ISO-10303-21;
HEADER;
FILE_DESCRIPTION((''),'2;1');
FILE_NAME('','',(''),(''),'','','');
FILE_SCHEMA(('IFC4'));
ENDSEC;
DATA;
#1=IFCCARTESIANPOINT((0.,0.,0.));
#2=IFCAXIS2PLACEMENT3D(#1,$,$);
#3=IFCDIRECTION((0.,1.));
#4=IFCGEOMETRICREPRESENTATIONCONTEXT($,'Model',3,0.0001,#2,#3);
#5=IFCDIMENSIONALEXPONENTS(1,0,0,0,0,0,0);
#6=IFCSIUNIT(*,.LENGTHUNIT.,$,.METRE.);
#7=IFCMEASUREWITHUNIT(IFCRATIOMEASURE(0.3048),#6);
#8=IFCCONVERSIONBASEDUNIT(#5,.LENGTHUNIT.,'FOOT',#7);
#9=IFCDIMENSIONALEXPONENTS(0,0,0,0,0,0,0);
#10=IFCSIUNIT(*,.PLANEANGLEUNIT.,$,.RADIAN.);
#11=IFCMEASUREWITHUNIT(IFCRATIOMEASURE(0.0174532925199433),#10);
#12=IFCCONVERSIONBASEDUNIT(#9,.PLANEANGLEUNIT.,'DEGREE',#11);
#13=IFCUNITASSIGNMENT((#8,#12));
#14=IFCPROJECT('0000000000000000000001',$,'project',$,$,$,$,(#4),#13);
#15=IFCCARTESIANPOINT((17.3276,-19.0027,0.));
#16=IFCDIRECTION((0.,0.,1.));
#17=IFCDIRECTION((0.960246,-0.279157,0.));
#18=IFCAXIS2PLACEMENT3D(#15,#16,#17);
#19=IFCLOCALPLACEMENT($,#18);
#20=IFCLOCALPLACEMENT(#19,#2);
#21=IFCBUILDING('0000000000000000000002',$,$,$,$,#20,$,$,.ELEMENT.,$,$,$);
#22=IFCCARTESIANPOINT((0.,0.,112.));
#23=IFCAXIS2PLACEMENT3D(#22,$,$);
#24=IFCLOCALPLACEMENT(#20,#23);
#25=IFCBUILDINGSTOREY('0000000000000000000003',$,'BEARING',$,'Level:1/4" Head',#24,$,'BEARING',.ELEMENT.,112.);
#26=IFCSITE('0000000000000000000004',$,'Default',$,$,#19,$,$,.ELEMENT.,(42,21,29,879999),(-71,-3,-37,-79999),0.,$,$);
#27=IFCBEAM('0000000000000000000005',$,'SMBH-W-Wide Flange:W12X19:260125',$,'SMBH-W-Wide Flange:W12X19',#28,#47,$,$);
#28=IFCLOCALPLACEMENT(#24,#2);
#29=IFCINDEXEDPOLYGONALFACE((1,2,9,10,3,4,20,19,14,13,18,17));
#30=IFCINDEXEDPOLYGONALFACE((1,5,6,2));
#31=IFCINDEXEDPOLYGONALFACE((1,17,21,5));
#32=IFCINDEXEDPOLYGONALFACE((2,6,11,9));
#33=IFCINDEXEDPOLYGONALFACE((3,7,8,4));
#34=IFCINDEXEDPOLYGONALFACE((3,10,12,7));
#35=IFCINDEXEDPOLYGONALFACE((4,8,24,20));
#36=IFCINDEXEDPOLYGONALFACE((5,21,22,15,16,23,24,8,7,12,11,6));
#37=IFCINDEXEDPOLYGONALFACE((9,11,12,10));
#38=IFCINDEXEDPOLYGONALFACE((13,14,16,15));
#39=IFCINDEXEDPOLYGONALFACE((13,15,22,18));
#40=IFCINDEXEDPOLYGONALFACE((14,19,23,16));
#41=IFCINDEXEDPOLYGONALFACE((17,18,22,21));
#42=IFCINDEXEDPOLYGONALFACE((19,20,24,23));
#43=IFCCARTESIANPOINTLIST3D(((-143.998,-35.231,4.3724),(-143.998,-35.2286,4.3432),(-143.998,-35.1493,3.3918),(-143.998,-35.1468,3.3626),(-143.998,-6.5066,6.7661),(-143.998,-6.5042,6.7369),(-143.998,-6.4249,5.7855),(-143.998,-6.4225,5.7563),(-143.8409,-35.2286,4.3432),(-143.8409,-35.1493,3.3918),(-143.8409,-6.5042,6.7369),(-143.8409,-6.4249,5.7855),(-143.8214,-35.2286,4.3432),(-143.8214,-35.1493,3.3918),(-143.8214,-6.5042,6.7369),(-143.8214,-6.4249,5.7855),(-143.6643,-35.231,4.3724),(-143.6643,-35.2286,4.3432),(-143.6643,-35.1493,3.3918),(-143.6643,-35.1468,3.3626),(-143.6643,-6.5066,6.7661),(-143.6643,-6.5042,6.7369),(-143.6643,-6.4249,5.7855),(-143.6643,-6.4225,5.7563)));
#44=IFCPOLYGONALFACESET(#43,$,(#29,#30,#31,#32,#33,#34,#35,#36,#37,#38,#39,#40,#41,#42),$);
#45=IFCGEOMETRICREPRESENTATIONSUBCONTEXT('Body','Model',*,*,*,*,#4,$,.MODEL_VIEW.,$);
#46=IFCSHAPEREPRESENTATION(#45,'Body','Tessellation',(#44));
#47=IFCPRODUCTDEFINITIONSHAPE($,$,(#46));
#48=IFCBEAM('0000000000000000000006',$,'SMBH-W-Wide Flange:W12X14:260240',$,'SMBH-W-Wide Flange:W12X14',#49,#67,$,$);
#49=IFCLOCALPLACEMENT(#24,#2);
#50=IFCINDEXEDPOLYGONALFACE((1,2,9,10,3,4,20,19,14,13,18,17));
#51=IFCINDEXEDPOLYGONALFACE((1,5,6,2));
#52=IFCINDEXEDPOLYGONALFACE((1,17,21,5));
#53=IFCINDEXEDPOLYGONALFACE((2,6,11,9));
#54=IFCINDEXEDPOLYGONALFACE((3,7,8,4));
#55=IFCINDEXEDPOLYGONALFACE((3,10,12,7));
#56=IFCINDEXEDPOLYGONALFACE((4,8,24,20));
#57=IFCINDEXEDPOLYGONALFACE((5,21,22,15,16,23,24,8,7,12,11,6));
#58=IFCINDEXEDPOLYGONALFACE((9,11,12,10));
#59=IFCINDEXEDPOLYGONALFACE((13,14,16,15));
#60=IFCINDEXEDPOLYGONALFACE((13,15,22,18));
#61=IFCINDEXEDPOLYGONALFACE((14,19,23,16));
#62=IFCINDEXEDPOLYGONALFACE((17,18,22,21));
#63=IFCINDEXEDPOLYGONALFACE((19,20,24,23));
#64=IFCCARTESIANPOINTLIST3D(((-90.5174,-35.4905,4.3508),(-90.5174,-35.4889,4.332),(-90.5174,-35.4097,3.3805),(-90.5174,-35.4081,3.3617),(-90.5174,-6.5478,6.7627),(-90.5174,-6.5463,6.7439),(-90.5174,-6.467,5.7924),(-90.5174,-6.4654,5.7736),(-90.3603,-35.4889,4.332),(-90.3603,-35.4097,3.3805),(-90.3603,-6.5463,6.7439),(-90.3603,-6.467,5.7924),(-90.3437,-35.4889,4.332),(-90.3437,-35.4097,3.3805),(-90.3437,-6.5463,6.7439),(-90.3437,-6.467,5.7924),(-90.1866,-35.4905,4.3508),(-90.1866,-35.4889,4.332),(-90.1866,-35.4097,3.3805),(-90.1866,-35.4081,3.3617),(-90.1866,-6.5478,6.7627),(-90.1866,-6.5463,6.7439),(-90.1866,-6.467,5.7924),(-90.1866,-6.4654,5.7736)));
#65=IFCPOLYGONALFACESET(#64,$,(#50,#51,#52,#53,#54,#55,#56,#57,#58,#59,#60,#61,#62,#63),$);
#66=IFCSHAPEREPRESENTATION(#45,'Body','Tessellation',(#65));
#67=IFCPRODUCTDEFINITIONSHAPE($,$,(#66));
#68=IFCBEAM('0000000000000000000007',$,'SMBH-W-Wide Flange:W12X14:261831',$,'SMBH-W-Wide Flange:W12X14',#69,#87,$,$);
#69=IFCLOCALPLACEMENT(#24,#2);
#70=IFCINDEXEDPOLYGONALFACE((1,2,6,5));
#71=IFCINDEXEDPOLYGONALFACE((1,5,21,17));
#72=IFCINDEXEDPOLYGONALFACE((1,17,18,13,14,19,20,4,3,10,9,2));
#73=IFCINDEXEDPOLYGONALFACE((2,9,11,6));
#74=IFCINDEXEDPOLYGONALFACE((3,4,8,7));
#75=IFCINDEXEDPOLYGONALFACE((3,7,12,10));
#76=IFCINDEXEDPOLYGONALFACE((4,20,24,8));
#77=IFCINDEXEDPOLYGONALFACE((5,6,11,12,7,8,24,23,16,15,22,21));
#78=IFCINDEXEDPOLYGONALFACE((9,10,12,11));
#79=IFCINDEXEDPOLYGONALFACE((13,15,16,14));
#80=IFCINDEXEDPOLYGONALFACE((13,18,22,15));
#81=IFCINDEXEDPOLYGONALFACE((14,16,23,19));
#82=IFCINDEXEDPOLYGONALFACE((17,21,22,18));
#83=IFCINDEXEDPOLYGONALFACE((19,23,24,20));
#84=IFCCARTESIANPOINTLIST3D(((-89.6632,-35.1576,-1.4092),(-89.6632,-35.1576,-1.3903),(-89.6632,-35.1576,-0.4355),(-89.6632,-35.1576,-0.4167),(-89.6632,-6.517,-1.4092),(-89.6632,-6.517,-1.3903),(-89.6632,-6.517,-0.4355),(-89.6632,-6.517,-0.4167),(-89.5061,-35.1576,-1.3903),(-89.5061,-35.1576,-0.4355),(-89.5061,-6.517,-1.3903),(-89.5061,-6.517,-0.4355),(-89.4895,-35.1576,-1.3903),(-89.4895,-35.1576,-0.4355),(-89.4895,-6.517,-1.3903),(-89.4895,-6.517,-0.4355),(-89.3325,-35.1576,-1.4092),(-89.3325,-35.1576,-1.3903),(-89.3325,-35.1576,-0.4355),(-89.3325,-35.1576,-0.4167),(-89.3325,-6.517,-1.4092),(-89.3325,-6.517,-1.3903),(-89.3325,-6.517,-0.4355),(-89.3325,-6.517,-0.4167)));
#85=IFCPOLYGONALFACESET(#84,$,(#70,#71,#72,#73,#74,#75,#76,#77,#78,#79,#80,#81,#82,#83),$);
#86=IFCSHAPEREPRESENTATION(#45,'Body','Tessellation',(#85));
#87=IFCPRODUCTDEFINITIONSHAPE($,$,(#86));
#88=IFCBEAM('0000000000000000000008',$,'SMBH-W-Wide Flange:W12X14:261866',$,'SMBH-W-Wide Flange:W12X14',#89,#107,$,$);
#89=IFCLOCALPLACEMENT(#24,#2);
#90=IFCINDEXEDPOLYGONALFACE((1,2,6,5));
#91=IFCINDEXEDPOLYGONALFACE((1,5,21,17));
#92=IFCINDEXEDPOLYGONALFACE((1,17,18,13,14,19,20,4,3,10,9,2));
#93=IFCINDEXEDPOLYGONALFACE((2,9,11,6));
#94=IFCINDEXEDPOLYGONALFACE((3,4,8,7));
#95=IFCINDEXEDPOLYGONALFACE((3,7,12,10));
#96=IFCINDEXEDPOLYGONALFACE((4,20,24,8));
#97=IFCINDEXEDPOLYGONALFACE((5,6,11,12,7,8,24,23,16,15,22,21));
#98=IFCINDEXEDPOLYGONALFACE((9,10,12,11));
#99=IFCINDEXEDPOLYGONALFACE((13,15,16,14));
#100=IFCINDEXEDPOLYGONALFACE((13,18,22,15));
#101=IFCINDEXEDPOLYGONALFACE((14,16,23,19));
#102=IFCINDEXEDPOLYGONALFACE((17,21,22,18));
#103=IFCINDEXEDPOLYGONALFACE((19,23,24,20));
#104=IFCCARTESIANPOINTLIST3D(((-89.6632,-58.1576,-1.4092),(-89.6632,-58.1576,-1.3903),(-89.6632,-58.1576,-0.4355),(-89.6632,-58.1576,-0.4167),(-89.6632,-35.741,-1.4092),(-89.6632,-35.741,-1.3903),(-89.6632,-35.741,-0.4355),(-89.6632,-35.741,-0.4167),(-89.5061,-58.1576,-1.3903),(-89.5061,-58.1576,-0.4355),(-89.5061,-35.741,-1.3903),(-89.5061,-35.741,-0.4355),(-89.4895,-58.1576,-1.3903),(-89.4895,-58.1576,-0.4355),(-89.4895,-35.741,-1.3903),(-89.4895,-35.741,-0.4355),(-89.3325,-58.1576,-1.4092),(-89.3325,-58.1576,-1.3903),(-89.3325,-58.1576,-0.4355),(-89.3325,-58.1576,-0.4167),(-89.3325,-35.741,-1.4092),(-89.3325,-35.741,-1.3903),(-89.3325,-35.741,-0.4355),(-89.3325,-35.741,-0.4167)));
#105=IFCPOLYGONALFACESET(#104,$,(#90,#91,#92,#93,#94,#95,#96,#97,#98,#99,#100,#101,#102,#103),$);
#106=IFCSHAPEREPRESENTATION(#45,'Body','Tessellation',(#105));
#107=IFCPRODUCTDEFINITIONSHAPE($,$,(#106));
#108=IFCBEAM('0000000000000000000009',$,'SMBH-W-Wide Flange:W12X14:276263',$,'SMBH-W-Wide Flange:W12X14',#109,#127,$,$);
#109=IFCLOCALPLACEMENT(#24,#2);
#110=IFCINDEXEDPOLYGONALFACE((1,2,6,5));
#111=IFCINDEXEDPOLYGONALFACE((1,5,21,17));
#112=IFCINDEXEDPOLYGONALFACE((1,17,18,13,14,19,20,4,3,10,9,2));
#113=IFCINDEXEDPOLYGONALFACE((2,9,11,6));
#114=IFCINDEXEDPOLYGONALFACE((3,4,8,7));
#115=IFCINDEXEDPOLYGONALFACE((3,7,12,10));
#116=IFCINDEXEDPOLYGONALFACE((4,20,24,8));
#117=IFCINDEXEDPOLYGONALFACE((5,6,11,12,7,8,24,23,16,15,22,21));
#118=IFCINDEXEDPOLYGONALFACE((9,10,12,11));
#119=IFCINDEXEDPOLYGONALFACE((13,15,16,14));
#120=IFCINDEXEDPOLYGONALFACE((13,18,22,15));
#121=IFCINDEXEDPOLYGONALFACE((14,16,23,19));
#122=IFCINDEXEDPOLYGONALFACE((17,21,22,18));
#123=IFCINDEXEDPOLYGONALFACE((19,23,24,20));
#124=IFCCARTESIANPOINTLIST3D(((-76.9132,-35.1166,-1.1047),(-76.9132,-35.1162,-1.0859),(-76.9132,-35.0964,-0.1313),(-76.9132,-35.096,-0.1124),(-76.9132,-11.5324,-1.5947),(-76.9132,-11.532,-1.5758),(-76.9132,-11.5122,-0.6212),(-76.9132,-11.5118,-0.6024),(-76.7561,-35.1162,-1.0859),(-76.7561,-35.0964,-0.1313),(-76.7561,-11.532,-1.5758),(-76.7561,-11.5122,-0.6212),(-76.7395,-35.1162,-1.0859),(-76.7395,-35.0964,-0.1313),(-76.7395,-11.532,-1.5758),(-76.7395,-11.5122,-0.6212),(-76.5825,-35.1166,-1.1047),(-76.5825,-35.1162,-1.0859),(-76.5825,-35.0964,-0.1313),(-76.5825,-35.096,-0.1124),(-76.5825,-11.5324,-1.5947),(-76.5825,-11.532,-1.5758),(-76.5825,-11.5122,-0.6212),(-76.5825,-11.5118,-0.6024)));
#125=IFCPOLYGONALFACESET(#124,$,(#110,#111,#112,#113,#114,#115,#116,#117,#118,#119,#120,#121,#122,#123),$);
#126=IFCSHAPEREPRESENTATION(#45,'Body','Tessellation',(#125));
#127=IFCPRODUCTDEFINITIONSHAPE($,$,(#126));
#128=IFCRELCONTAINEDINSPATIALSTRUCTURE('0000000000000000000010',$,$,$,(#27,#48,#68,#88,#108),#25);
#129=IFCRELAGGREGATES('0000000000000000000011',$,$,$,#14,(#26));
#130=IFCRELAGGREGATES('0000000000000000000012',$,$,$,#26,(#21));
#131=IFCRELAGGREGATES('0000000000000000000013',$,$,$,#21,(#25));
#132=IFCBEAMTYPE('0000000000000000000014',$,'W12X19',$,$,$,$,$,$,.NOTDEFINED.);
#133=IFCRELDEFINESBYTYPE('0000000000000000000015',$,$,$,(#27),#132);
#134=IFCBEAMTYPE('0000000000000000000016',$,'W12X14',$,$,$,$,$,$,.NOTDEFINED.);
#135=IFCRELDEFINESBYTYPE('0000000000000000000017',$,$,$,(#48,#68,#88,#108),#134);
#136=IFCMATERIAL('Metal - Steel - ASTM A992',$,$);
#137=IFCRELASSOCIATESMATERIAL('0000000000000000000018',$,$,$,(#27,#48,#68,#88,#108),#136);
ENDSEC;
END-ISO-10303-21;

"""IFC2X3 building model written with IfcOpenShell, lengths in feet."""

from ifc_helpers import new_model, entity, si_unit, converted_unit, direction, frame, frame_2d, origin, place, context, subcontext, project, spatial, i_section, extrude, material, type_object, element, save


model = new_model("IFC2X3")

# Units and contexts
model_context = context("Model", 3, precision=0.0001, world=origin(), true_north=direction((0.0, 1.0)))
body_context = subcontext(model_context, "Body", "Model", "MODEL_VIEW")
ifc_project = project(units=[converted_unit("LENGTHUNIT", "FOOT", entity("IfcRatioMeasure", 0.3048), si_unit("LENGTHUNIT", "METRE"), dimensions=[1, 0, 0, 0, 0, 0, 0]), converted_unit("PLANEANGLEUNIT", "DEGREE", entity("IfcRatioMeasure", 0.0174532925199433), si_unit("PLANEANGLEUNIT", "RADIAN"), dimensions=[0, 0, 0, 0, 0, 0, 0])], contexts=[model_context])

# Site, building, storey
site_placement = place(None, frame((17.3276, -19.0027, 0.0), z_axis=(0.0, 0.0, 1.0), x_axis=(0.960246, -0.279157, 0.0)))
site = spatial("IfcSite", under=ifc_project, at=site_placement, Name="Default", CompositionType="ELEMENT", RefLatitude=(42, 21, 29, 879999), RefLongitude=(-71, -3, -37, -79999), RefElevation=0.0)
building_placement = place(site_placement, origin())
building = spatial("IfcBuilding", under=site, at=building_placement, CompositionType="ELEMENT")
storey_placement = place(building_placement, frame((0.0, 0.0, 112.0)))
storey = spatial("IfcBuildingStorey", under=building, at=storey_placement, Name="BEARING", ObjectType="Level:1/4\" Head", LongName="BEARING", CompositionType="ELEMENT", Elevation=112.0)

# Beams
ifc_material_1 = material(Name="Metal - Steel - ASTM A992")
beam_type_1 = type_object("IfcBeamType", Name="W12X19", PredefinedType="NOTDEFINED")
beam_1_placement = place(storey_placement, frame((-143.8312, -6.517, 6.8907), z_axis=(0.0, -0.083045, 0.996546), x_axis=(0.0, -0.996546, -0.083045)))
element("IfcBeam", 1, at=beam_1_placement, inside=storey, type_object=beam_type_1, material=ifc_material_1, Name="SMBH-W-Wide Flange:W12X19:260125", ObjectType="SMBH-W-Wide Flange:W12X19", context=body_context, shape_type="SweptSolid", body=[
    extrude(i_section(OverallWidth=0.3337, OverallDepth=1.0133, WebThickness=0.0195, FlangeThickness=0.0293, at=frame_2d((0.0, 0.0), x_axis=(0.0, 1.0))), frame((0.0, 0.0, -0.6317), z_axis=(1.0, 0.0, 0.0), x_axis=(0.0, 0.0, -1.0)), (0.0, 0.0, 1.0), 28.8239),
])
beam_type_2 = type_object("IfcBeamType", Name="W12X14", PredefinedType="NOTDEFINED")
beam_2_placement = place(storey_placement, frame((-90.352, -35.5009, 4.4754), z_axis=(0.0, -0.083045, 0.996546), x_axis=(0.0, 0.996546, 0.083045)))
element("IfcBeam", 2, at=beam_2_placement, inside=storey, type_object=beam_type_2, material=ifc_material_1, Name="SMBH-W-Wide Flange:W12X14:260240", ObjectType="SMBH-W-Wide Flange:W12X14", context=body_context, shape_type="SweptSolid", body=[
    extrude(i_section(OverallWidth=0.3307, OverallDepth=0.9925, WebThickness=0.0166, FlangeThickness=0.0189, at=frame_2d((0.0, 0.0), x_axis=(0.0, 1.0))), frame((0.0, 0.0, -0.6213), z_axis=(1.0, 0.0, 0.0), x_axis=(0.0, 0.0, -1.0)), (0.0, 0.0, 1.0), 29.043),
])
beam_3_placement = place(storey_placement, frame((-89.4978, -6.517, 0.0), z_axis=(0.0, 0.0, 1.0), x_axis=(0.0, -1.0, 0.0)))
element("IfcBeam", 3, at=beam_3_placement, inside=storey, type_object=beam_type_2, material=ifc_material_1, Name="SMBH-W-Wide Flange:W12X14:261831", ObjectType="SMBH-W-Wide Flange:W12X14", context=body_context, shape_type="SweptSolid", body=[
    extrude(i_section(OverallWidth=0.3307, OverallDepth=0.9925, WebThickness=0.0166, FlangeThickness=0.0189, at=frame_2d((0.0, 0.0), x_axis=(0.0, 1.0))), frame((0.0, 0.0, -0.9129), z_axis=(1.0, 0.0, 0.0), x_axis=(0.0, 0.0, -1.0)), (0.0, 0.0, 1.0), 28.6406),
])
beam_4_placement = place(storey_placement, frame((-89.4978, -35.4493, 0.0), z_axis=(0.0, 0.0, 1.0), x_axis=(0.0, -1.0, 0.0)))
element("IfcBeam", 4, at=beam_4_placement, inside=storey, type_object=beam_type_2, material=ifc_material_1, Name="SMBH-W-Wide Flange:W12X14:261866", ObjectType="SMBH-W-Wide Flange:W12X14", context=body_context, shape_type="SweptSolid", body=[
    extrude(i_section(OverallWidth=0.3307, OverallDepth=0.9925, WebThickness=0.0166, FlangeThickness=0.0189, at=frame_2d((0.0, 0.0), x_axis=(0.0, 1.0))), frame((0.2917, 0.0, -0.9129), z_axis=(1.0, 0.0, 0.0), x_axis=(0.0, 0.0, -1.0)), (0.0, 0.0, 1.0), 22.4167),
])
beam_5_placement = place(storey_placement, frame((-76.7478, -11.2201, -0.4834), z_axis=(0.0, 0.020769, 0.999784), x_axis=(0.0, -0.999784, 0.020769)))
element("IfcBeam", 5, at=beam_5_placement, inside=storey, type_object=beam_type_2, material=ifc_material_1, Name="SMBH-W-Wide Flange:W12X14:276263", ObjectType="SMBH-W-Wide Flange:W12X14", context=body_context, shape_type="SweptSolid", body=[
    extrude(i_section(OverallWidth=0.3307, OverallDepth=0.9925, WebThickness=0.0166, FlangeThickness=0.0189, at=frame_2d((0.0, 0.0), x_axis=(0.0, 1.0))), frame((0.2891, 0.0, -0.6213), z_axis=(1.0, 0.0, 0.0), x_axis=(0.0, 0.0, -1.0)), (0.0, 0.0, 1.0), 23.5893),
])

save(model, "model.ifc")
